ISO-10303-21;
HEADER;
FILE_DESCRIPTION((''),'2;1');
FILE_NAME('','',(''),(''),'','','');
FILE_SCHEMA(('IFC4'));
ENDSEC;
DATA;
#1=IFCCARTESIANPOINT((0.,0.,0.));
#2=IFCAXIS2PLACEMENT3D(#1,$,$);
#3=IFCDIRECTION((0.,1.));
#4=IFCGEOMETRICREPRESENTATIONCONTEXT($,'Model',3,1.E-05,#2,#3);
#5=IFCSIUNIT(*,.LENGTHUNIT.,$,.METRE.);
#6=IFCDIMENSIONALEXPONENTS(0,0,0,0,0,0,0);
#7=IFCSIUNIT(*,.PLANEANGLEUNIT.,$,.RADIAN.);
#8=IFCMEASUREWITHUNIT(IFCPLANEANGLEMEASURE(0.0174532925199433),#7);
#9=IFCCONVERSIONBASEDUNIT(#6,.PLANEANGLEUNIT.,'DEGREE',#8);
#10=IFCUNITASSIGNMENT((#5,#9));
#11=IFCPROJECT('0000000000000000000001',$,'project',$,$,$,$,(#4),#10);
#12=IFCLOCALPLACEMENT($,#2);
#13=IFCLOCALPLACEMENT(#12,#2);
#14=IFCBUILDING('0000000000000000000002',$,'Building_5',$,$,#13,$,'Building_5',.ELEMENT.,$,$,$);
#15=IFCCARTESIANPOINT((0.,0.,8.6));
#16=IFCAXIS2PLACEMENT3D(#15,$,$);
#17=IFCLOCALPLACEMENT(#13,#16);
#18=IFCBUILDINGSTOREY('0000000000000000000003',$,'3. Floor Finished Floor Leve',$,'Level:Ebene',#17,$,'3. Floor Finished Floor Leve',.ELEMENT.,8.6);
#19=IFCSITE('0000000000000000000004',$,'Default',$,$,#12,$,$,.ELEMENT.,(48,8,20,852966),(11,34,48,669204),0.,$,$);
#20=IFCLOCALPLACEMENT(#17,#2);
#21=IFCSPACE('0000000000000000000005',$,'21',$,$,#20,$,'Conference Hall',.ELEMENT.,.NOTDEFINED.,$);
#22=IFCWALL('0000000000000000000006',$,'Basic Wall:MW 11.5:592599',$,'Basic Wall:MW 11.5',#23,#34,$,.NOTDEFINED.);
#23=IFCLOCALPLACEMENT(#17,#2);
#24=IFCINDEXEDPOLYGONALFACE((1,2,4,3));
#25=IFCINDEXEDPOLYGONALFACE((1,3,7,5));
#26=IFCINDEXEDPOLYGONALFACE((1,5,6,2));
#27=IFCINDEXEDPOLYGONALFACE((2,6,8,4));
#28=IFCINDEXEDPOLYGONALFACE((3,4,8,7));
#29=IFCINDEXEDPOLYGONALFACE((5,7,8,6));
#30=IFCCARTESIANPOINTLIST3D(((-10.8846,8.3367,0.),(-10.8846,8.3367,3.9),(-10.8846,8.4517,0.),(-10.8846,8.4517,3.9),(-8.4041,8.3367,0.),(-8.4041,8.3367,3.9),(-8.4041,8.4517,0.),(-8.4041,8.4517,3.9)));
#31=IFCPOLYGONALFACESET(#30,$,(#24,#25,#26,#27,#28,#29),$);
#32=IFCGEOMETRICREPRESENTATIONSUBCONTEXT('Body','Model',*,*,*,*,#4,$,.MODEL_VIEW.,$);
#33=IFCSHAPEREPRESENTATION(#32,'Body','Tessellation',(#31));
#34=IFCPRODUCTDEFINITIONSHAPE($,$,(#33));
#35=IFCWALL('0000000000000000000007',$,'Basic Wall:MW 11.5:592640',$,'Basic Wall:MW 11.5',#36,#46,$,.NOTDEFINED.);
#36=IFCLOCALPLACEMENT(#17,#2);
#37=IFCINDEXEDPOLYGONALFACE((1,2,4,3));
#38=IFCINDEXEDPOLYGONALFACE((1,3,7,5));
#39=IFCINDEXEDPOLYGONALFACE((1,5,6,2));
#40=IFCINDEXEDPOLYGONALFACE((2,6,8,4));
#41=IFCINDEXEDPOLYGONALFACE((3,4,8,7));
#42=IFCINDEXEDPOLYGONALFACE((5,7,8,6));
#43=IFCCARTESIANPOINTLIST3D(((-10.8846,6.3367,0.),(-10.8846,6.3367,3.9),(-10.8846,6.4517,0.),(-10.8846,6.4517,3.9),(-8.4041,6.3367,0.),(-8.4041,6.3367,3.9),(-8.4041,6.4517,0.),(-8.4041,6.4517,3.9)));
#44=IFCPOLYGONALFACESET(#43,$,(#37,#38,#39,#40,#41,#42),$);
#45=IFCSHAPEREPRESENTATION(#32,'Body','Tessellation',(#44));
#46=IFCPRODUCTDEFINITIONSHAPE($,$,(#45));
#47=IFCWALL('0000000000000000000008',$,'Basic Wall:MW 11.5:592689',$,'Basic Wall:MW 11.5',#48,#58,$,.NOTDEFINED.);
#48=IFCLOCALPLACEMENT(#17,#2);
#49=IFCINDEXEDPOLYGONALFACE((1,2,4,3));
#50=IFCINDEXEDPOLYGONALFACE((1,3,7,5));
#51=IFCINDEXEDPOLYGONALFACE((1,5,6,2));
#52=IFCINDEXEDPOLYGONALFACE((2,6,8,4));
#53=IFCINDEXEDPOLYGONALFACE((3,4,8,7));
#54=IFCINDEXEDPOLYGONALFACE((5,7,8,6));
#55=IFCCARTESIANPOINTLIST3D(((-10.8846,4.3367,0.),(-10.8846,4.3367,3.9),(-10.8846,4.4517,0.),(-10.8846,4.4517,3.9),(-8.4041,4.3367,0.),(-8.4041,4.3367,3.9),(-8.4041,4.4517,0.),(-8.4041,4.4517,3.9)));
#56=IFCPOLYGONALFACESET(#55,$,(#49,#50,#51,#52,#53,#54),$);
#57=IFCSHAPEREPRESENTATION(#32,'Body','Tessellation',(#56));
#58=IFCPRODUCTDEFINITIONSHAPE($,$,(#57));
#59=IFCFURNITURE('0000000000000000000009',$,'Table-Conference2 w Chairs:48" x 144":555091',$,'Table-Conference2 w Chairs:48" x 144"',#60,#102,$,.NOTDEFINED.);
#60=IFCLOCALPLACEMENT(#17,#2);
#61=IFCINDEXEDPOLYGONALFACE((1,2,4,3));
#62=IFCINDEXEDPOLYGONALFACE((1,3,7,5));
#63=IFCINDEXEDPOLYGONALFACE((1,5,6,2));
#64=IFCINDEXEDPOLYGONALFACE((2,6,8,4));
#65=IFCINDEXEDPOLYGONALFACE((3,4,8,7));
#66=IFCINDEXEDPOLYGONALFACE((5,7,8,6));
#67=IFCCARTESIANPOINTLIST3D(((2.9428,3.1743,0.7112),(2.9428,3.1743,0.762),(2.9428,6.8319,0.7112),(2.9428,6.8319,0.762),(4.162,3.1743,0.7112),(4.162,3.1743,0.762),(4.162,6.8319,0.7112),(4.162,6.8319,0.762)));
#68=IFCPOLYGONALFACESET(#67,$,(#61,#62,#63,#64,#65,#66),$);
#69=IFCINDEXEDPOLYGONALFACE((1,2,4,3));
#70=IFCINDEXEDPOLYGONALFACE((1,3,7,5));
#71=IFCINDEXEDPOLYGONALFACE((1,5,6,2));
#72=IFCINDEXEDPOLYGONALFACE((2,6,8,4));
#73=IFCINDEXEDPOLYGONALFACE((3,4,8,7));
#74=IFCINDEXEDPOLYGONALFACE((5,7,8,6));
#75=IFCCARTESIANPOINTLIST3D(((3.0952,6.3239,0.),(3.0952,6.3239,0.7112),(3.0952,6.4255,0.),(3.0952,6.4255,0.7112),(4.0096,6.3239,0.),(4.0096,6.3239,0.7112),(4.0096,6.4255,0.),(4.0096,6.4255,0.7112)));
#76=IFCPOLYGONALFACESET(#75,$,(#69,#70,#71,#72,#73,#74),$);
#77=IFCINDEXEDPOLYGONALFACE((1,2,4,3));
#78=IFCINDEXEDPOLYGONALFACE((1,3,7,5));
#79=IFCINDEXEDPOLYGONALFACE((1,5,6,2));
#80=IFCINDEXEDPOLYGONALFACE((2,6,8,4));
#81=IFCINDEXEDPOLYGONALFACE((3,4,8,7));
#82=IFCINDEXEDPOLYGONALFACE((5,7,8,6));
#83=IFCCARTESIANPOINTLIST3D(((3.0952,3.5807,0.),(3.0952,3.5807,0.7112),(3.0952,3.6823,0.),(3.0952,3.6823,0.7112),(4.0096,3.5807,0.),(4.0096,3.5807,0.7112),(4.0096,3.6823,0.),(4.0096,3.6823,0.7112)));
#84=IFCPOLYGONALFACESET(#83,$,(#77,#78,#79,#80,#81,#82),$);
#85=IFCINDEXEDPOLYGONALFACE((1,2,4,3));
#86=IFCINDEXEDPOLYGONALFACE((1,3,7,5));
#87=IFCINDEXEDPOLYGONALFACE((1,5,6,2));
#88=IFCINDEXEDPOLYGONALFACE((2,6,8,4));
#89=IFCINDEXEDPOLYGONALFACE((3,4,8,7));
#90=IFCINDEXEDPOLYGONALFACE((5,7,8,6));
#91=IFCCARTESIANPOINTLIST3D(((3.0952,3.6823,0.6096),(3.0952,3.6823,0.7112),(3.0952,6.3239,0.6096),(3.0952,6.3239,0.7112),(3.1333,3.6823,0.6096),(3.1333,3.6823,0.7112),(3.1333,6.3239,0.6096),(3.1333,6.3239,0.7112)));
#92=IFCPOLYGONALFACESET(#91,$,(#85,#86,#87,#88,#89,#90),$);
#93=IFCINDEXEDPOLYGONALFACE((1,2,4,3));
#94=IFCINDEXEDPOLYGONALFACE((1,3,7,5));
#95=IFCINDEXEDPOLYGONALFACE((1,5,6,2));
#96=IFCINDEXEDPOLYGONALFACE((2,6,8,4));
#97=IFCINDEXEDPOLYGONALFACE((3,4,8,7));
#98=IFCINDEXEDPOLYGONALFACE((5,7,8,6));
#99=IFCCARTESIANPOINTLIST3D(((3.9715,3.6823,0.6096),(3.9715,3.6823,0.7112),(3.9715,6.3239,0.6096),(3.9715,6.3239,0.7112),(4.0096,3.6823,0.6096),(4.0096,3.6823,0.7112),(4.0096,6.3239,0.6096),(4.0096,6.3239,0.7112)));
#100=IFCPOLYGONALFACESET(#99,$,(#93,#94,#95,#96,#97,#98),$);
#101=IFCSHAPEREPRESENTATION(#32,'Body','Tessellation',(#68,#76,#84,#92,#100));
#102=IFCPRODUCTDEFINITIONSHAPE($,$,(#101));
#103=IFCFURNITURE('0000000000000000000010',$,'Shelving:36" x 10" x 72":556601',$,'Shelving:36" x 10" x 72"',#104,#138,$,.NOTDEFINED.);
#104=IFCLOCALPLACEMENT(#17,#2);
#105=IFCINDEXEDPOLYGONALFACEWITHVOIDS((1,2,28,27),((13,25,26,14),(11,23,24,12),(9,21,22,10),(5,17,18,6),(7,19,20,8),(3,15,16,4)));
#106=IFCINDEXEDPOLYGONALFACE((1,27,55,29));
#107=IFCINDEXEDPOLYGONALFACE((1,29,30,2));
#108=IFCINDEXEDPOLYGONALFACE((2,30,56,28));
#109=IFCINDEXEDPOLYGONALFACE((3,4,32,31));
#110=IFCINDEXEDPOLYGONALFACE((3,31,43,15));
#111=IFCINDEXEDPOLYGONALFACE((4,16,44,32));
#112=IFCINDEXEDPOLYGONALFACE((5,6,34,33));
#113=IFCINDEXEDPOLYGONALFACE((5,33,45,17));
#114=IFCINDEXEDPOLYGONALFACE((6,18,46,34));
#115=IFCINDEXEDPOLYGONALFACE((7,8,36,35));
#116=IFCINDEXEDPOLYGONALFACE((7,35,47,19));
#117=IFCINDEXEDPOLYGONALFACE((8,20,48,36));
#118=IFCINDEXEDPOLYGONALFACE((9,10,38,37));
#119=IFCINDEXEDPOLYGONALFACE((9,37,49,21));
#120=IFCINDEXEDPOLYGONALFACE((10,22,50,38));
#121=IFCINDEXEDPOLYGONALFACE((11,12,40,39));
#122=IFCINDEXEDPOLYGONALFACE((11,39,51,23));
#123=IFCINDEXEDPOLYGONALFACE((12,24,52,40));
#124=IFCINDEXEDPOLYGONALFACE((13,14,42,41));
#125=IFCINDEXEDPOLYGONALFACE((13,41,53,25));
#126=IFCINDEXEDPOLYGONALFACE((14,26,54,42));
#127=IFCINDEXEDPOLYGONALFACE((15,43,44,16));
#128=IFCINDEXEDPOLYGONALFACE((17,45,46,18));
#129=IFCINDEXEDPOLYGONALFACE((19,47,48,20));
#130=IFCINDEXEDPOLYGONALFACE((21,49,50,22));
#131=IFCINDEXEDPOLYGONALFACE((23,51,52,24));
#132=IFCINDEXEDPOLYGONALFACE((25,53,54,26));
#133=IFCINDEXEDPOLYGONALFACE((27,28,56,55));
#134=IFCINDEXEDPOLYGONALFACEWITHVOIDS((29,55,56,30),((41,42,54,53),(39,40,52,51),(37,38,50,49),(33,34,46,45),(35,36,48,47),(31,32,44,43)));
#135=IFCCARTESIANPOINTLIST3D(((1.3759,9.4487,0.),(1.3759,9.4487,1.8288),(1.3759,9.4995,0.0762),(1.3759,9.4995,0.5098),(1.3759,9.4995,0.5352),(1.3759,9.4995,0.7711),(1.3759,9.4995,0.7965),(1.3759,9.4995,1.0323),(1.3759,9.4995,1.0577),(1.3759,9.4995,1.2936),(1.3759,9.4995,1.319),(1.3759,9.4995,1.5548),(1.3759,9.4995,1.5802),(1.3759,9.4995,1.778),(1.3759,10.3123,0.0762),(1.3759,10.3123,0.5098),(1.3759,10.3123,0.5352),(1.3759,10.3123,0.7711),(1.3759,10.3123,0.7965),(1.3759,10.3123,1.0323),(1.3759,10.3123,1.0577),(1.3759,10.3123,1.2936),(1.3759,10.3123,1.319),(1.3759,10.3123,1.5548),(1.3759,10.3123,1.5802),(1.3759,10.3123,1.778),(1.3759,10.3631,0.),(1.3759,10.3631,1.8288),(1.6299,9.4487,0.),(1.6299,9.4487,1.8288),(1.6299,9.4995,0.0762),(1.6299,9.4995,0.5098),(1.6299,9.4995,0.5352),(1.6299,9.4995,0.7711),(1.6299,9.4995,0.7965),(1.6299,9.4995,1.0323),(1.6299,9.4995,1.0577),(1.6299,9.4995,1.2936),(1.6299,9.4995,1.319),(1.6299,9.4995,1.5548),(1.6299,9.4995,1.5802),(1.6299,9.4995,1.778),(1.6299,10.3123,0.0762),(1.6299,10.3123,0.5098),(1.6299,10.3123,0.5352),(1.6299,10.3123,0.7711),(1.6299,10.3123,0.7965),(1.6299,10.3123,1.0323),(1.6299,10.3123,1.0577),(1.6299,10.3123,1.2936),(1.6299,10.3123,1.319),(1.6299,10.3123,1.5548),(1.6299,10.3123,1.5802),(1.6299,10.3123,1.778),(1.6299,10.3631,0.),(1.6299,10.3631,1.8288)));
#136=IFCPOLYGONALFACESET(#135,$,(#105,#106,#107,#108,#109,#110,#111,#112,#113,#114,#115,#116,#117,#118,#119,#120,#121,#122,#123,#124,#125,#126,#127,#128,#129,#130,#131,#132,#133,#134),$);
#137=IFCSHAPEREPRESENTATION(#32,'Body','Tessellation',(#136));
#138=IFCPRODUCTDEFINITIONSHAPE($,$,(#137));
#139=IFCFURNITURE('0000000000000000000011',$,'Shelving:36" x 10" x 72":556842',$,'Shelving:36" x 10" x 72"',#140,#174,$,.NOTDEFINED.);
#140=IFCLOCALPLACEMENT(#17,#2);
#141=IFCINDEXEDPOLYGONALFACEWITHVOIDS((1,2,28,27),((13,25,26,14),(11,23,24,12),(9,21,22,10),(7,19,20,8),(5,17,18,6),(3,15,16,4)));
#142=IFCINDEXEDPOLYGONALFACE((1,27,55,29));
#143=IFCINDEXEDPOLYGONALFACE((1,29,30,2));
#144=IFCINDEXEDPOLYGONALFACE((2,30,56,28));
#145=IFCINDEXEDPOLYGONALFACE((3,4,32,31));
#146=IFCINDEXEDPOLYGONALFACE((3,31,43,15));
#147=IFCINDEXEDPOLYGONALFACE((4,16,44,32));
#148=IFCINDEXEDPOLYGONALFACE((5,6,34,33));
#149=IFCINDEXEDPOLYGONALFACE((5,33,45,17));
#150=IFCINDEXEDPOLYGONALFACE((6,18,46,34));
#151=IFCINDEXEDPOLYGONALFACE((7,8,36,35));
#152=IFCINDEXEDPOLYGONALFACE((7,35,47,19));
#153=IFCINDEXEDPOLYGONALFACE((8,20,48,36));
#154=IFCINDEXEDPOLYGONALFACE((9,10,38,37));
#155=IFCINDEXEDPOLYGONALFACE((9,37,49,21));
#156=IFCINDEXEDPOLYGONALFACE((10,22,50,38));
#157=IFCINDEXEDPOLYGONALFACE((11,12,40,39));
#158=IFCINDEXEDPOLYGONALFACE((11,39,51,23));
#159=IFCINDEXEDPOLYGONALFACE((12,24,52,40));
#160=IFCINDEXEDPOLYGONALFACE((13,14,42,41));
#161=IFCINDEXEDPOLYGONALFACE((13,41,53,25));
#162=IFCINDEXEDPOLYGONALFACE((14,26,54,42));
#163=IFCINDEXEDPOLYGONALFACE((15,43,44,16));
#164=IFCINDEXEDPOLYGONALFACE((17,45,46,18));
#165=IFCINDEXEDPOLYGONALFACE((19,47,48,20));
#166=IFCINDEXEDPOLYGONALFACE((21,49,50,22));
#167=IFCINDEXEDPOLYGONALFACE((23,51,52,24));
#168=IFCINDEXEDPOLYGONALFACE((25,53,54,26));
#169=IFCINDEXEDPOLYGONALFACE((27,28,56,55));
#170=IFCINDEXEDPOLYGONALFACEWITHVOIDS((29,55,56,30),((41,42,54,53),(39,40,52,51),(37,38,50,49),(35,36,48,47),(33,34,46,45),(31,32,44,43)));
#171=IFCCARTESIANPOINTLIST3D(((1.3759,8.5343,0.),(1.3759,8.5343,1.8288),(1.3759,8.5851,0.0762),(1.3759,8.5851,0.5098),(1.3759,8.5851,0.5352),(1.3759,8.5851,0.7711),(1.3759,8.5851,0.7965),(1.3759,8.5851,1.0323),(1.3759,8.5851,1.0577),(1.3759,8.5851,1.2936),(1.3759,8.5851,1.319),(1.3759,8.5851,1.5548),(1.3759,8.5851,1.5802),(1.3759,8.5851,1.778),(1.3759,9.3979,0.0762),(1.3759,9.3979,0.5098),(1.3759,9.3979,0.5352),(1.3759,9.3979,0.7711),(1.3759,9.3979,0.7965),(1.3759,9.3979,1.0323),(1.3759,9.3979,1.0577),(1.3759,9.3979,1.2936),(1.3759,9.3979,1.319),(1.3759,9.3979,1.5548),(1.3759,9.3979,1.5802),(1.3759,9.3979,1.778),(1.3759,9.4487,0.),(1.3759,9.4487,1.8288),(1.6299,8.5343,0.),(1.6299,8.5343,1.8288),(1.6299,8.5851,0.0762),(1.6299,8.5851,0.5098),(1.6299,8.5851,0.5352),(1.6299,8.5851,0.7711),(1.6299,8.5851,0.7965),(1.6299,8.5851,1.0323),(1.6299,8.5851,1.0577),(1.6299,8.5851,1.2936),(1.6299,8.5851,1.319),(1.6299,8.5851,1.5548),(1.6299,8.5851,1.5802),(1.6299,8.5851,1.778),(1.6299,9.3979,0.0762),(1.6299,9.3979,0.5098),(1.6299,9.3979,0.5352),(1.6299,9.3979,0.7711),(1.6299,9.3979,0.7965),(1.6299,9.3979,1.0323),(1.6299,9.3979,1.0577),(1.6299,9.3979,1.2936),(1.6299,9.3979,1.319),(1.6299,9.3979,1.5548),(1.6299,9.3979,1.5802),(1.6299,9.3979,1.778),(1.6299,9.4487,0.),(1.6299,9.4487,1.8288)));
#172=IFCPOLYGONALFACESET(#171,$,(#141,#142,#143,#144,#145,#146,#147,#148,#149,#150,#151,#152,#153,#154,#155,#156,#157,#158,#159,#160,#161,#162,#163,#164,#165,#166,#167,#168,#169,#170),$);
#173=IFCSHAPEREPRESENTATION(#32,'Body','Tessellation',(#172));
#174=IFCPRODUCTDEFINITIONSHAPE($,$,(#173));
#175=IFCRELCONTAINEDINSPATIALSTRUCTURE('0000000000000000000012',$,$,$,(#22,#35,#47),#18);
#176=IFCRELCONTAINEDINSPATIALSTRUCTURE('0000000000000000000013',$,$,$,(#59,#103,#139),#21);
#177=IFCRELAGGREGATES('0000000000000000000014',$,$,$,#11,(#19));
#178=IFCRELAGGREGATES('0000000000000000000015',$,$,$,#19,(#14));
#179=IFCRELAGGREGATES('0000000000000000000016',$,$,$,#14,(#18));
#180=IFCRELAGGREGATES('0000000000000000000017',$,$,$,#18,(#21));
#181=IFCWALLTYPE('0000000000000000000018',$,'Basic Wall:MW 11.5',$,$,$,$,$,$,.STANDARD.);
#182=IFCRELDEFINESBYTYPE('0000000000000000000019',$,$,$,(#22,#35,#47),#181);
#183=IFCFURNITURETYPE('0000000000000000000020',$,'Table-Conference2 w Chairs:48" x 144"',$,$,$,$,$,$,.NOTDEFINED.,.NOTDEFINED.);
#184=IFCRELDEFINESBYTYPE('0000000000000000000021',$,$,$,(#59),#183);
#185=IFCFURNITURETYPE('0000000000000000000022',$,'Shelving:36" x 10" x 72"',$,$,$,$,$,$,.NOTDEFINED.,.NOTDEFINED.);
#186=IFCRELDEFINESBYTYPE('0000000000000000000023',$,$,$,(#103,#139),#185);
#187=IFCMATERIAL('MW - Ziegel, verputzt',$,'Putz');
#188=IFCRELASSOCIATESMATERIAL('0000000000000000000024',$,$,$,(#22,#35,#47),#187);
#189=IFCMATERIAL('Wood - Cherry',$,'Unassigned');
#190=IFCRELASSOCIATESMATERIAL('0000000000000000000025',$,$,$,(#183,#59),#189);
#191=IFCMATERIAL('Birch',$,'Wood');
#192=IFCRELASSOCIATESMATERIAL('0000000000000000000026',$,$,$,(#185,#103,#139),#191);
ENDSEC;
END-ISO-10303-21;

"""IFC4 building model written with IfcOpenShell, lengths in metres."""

from ifc_helpers import new_model, entity, si_unit, converted_unit, direction, frame, origin, place, context, subcontext, project, spatial, indexed_curve, outline, extrude, source, transform, mapped, material, type_object, type_shapes, element, save


model = new_model("IFC4")

# Units and contexts
model_context = context("Model", 3, precision=1e-05, world=origin(), true_north=direction((0.0, 1.0)))
body_context = subcontext(model_context, "Body", "Model", "MODEL_VIEW")
ifc_project = project(units=[si_unit("LENGTHUNIT", "METRE"), converted_unit("PLANEANGLEUNIT", "DEGREE", entity("IfcPlaneAngleMeasure", 0.0174532925199433), si_unit("PLANEANGLEUNIT", "RADIAN"), dimensions=[0, 0, 0, 0, 0, 0, 0])], contexts=[model_context])

# Site, building, storey
site_placement = place(None, origin())
site = spatial("IfcSite", under=ifc_project, at=site_placement, Name="Default", CompositionType="ELEMENT", RefLatitude=(48, 8, 20, 852966), RefLongitude=(11, 34, 48, 669204), RefElevation=0.0)
building_placement = place(site_placement, origin())
building = spatial("IfcBuilding", under=site, at=building_placement, Name="Building_5", LongName="Building_5", CompositionType="ELEMENT")
storey_placement = place(building_placement, frame((0.0, 0.0, 8.6)))
storey = spatial("IfcBuildingStorey", under=building, at=storey_placement, Name="3. Floor Finished Floor Leve", ObjectType="Level:Ebene", LongName="3. Floor Finished Floor Leve", CompositionType="ELEMENT", Elevation=8.6)

# Walls
ifc_material_1 = material(Name="MW - Ziegel, verputzt", Category="Putz")
wall_type_1 = type_object("IfcWallType", Name="Basic Wall:MW 11.5", PredefinedType="STANDARD")
for number, where, z_axis, x_axis, name in (
    (1, (-8.4041, 8.3942, 0.0), (0.0, 0.0, 1.0), (-1.0, 0.0, 0.0), "Basic Wall:MW 11.5:592599"),
    (2, (-8.4041, 6.3942, 0.0), (0.0, 0.0, 1.0), (-1.0, 0.0, 0.0), "Basic Wall:MW 11.5:592640"),
    (3, (-8.4041, 4.3942, 0.0), (0.0, 0.0, 1.0), (-1.0, 0.0, 0.0), "Basic Wall:MW 11.5:592689"),
):
    element("IfcWall", number, at=place(storey_placement, frame(where, z_axis=z_axis, x_axis=x_axis)), inside=storey, type_object=wall_type_1, material=ifc_material_1, Name=name, ObjectType="Basic Wall:MW 11.5", PredefinedType="NOTDEFINED", context=body_context, shape_type="SweptSolid", body=[
        extrude(outline(indexed_curve([(2.4805, 0.0575), (0.0, 0.0575), (0.0, -0.0575), (2.4805, -0.0575), (2.4805, 0.0575)], self_intersect=False)), origin(), (0.0, 0.0, 1.0), 3.9),
    ])

# Shared definitions
space_placement = place(storey_placement, origin())
space = spatial("IfcSpace", under=storey, at=space_placement, Name="21", LongName="Conference Hall", CompositionType="ELEMENT", PredefinedType="NOTDEFINED")

# Furniture
ifc_material_2 = material(Name="Wood - Cherry", Category="Unassigned")
furniture_type_1 = type_object("IfcFurnitureType", Name="Table-Conference2 w Chairs:48\" x 144\"", AssemblyPlace="NOTDEFINED", PredefinedType="NOTDEFINED", material=ifc_material_2)
shared_shape_1 = source(origin(), body_context, "Body", "SweptSolid", [
    extrude(outline(indexed_curve([(-0.6096, -1.8288), (0.6096, -1.8288), (0.6096, 1.8288), (-0.6096, 1.8288), (-0.6096, -1.8288)], self_intersect=False)), frame((0.0, 0.0, 0.7112), z_axis=(0.0, 0.0, 1.0), x_axis=(0.0, 1.0, 0.0)), (0.0, 0.0, 1.0), 0.0508),
    extrude(outline(indexed_curve([(-0.4572, -0.0508), (0.4572, -0.0508), (0.4572, 0.0508), (-0.4572, 0.0508), (-0.4572, -0.0508)], self_intersect=False)), frame((1.3716, 0.0, 0.0), z_axis=(0.0, 0.0, 1.0), x_axis=(0.0, 1.0, 0.0)), (0.0, 0.0, 1.0), 0.7112),
    extrude(outline(indexed_curve([(-0.4572, -0.0508), (0.4572, -0.0508), (0.4572, 0.0508), (-0.4572, 0.0508), (-0.4572, -0.0508)], self_intersect=False)), frame((-1.3716, 0.0, 0.0), z_axis=(0.0, 0.0, 1.0), x_axis=(0.0, 1.0, 0.0)), (0.0, 0.0, 1.0), 0.7112),
    extrude(outline(indexed_curve([(-1.3208, -0.0191), (1.3208, -0.0191), (1.3208, 0.0191), (-1.3208, 0.0191), (-1.3208, -0.0191)], self_intersect=False)), frame((0.0, 0.4382, 0.6096), z_axis=(0.0, 0.0, 1.0), x_axis=(-1.0, 0.0, 0.0)), (0.0, 0.0, 1.0), 0.1016),
    extrude(outline(indexed_curve([(-0.019, -1.3208), (0.019, -1.3208), (0.019, 1.3208), (-0.019, 1.3208), (-0.019, -1.3208)], self_intersect=False)), frame((0.0, -0.4382, 0.6096), z_axis=(0.0, 0.0, 1.0), x_axis=(0.0, 1.0, 0.0)), (0.0, 0.0, 1.0), 0.1016),
])
type_shapes(furniture_type_1, [shared_shape_1])
furniture_1_placement = place(space_placement, frame((3.5524, 5.0031, 0.0), z_axis=(0.0, 0.0, 1.0), x_axis=(0.0, 1.0, 0.0)))
element("IfcFurniture", 4, at=furniture_1_placement, inside=space, type_object=furniture_type_1, material=ifc_material_2, Name="Table-Conference2 w Chairs:48\" x 144\":555091", ObjectType="Table-Conference2 w Chairs:48\" x 144\"", PredefinedType="NOTDEFINED", context=body_context, shape_type="MappedRepresentation", body=[
    mapped(shared_shape_1, transform((0.0, 0.0, 0.0), scale=1.0)),
])
ifc_material_3 = material(Name="Birch", Category="Wood")
furniture_type_2 = type_object("IfcFurnitureType", Name="Shelving:36\" x 10\" x 72\"", AssemblyPlace="NOTDEFINED", PredefinedType="NOTDEFINED", material=ifc_material_3)
shared_shape_2 = source(origin(), body_context, "Body", "SweptSolid", [
    extrude(outline(indexed_curve([(-0.4572, -0.9144), (0.4572, -0.9144), (0.4572, 0.9144), (-0.4572, 0.9144), (-0.4572, -0.9144)], self_intersect=False), holes=[indexed_curve([(-0.4064, 0.8636), (0.4064, 0.8636), (0.4064, 0.6658), (-0.4064, 0.6658), (-0.4064, 0.8636)], self_intersect=False), indexed_curve([(-0.4064, -0.8382), (-0.4064, -0.4046), (0.4064, -0.4046), (0.4064, -0.8382), (-0.4064, -0.8382)], self_intersect=False), indexed_curve([(0.4064, 0.1433), (-0.4064, 0.1433), (-0.4064, 0.3792), (0.4064, 0.3792), (0.4064, 0.1433)], self_intersect=False), indexed_curve([(-0.4064, 0.6404), (0.4064, 0.6404), (0.4064, 0.4046), (-0.4064, 0.4046), (-0.4064, 0.6404)], self_intersect=False), indexed_curve([(-0.4064, 0.1179), (0.4064, 0.1179), (0.4064, -0.1179), (-0.4064, -0.1179), (-0.4064, 0.1179)], self_intersect=False), indexed_curve([(-0.4064, -0.1433), (0.4064, -0.1433), (0.4064, -0.3792), (-0.4064, -0.3792), (-0.4064, -0.1433)], self_intersect=False)]), frame((0.0, -0.4318, 0.9144), z_axis=(0.0, 1.0, 0.0), x_axis=(-1.0, 0.0, 0.0)), (0.0, 0.0, 1.0), 0.254),
])
type_shapes(furniture_type_2, [shared_shape_2])
for number, where, z_axis, x_axis, name in (
    (5, (1.8077, 9.9059, 0.0), (0.0, 0.0, 1.0), (0.0, -1.0, 0.0), "Shelving:36\" x 10\" x 72\":556601"),
    (6, (1.8077, 8.9915, 0.0), (0.0, 0.0, 1.0), (0.0, -1.0, 0.0), "Shelving:36\" x 10\" x 72\":556842"),
):
    element("IfcFurniture", number, at=place(space_placement, frame(where, z_axis=z_axis, x_axis=x_axis)), inside=space, type_object=furniture_type_2, material=ifc_material_3, Name=name, ObjectType="Shelving:36\" x 10\" x 72\"", PredefinedType="NOTDEFINED", context=body_context, shape_type="MappedRepresentation", body=[
        mapped(shared_shape_2, transform((0.0, 0.0, 0.0), scale=1.0)),
    ])

save(model, "model.ifc")
